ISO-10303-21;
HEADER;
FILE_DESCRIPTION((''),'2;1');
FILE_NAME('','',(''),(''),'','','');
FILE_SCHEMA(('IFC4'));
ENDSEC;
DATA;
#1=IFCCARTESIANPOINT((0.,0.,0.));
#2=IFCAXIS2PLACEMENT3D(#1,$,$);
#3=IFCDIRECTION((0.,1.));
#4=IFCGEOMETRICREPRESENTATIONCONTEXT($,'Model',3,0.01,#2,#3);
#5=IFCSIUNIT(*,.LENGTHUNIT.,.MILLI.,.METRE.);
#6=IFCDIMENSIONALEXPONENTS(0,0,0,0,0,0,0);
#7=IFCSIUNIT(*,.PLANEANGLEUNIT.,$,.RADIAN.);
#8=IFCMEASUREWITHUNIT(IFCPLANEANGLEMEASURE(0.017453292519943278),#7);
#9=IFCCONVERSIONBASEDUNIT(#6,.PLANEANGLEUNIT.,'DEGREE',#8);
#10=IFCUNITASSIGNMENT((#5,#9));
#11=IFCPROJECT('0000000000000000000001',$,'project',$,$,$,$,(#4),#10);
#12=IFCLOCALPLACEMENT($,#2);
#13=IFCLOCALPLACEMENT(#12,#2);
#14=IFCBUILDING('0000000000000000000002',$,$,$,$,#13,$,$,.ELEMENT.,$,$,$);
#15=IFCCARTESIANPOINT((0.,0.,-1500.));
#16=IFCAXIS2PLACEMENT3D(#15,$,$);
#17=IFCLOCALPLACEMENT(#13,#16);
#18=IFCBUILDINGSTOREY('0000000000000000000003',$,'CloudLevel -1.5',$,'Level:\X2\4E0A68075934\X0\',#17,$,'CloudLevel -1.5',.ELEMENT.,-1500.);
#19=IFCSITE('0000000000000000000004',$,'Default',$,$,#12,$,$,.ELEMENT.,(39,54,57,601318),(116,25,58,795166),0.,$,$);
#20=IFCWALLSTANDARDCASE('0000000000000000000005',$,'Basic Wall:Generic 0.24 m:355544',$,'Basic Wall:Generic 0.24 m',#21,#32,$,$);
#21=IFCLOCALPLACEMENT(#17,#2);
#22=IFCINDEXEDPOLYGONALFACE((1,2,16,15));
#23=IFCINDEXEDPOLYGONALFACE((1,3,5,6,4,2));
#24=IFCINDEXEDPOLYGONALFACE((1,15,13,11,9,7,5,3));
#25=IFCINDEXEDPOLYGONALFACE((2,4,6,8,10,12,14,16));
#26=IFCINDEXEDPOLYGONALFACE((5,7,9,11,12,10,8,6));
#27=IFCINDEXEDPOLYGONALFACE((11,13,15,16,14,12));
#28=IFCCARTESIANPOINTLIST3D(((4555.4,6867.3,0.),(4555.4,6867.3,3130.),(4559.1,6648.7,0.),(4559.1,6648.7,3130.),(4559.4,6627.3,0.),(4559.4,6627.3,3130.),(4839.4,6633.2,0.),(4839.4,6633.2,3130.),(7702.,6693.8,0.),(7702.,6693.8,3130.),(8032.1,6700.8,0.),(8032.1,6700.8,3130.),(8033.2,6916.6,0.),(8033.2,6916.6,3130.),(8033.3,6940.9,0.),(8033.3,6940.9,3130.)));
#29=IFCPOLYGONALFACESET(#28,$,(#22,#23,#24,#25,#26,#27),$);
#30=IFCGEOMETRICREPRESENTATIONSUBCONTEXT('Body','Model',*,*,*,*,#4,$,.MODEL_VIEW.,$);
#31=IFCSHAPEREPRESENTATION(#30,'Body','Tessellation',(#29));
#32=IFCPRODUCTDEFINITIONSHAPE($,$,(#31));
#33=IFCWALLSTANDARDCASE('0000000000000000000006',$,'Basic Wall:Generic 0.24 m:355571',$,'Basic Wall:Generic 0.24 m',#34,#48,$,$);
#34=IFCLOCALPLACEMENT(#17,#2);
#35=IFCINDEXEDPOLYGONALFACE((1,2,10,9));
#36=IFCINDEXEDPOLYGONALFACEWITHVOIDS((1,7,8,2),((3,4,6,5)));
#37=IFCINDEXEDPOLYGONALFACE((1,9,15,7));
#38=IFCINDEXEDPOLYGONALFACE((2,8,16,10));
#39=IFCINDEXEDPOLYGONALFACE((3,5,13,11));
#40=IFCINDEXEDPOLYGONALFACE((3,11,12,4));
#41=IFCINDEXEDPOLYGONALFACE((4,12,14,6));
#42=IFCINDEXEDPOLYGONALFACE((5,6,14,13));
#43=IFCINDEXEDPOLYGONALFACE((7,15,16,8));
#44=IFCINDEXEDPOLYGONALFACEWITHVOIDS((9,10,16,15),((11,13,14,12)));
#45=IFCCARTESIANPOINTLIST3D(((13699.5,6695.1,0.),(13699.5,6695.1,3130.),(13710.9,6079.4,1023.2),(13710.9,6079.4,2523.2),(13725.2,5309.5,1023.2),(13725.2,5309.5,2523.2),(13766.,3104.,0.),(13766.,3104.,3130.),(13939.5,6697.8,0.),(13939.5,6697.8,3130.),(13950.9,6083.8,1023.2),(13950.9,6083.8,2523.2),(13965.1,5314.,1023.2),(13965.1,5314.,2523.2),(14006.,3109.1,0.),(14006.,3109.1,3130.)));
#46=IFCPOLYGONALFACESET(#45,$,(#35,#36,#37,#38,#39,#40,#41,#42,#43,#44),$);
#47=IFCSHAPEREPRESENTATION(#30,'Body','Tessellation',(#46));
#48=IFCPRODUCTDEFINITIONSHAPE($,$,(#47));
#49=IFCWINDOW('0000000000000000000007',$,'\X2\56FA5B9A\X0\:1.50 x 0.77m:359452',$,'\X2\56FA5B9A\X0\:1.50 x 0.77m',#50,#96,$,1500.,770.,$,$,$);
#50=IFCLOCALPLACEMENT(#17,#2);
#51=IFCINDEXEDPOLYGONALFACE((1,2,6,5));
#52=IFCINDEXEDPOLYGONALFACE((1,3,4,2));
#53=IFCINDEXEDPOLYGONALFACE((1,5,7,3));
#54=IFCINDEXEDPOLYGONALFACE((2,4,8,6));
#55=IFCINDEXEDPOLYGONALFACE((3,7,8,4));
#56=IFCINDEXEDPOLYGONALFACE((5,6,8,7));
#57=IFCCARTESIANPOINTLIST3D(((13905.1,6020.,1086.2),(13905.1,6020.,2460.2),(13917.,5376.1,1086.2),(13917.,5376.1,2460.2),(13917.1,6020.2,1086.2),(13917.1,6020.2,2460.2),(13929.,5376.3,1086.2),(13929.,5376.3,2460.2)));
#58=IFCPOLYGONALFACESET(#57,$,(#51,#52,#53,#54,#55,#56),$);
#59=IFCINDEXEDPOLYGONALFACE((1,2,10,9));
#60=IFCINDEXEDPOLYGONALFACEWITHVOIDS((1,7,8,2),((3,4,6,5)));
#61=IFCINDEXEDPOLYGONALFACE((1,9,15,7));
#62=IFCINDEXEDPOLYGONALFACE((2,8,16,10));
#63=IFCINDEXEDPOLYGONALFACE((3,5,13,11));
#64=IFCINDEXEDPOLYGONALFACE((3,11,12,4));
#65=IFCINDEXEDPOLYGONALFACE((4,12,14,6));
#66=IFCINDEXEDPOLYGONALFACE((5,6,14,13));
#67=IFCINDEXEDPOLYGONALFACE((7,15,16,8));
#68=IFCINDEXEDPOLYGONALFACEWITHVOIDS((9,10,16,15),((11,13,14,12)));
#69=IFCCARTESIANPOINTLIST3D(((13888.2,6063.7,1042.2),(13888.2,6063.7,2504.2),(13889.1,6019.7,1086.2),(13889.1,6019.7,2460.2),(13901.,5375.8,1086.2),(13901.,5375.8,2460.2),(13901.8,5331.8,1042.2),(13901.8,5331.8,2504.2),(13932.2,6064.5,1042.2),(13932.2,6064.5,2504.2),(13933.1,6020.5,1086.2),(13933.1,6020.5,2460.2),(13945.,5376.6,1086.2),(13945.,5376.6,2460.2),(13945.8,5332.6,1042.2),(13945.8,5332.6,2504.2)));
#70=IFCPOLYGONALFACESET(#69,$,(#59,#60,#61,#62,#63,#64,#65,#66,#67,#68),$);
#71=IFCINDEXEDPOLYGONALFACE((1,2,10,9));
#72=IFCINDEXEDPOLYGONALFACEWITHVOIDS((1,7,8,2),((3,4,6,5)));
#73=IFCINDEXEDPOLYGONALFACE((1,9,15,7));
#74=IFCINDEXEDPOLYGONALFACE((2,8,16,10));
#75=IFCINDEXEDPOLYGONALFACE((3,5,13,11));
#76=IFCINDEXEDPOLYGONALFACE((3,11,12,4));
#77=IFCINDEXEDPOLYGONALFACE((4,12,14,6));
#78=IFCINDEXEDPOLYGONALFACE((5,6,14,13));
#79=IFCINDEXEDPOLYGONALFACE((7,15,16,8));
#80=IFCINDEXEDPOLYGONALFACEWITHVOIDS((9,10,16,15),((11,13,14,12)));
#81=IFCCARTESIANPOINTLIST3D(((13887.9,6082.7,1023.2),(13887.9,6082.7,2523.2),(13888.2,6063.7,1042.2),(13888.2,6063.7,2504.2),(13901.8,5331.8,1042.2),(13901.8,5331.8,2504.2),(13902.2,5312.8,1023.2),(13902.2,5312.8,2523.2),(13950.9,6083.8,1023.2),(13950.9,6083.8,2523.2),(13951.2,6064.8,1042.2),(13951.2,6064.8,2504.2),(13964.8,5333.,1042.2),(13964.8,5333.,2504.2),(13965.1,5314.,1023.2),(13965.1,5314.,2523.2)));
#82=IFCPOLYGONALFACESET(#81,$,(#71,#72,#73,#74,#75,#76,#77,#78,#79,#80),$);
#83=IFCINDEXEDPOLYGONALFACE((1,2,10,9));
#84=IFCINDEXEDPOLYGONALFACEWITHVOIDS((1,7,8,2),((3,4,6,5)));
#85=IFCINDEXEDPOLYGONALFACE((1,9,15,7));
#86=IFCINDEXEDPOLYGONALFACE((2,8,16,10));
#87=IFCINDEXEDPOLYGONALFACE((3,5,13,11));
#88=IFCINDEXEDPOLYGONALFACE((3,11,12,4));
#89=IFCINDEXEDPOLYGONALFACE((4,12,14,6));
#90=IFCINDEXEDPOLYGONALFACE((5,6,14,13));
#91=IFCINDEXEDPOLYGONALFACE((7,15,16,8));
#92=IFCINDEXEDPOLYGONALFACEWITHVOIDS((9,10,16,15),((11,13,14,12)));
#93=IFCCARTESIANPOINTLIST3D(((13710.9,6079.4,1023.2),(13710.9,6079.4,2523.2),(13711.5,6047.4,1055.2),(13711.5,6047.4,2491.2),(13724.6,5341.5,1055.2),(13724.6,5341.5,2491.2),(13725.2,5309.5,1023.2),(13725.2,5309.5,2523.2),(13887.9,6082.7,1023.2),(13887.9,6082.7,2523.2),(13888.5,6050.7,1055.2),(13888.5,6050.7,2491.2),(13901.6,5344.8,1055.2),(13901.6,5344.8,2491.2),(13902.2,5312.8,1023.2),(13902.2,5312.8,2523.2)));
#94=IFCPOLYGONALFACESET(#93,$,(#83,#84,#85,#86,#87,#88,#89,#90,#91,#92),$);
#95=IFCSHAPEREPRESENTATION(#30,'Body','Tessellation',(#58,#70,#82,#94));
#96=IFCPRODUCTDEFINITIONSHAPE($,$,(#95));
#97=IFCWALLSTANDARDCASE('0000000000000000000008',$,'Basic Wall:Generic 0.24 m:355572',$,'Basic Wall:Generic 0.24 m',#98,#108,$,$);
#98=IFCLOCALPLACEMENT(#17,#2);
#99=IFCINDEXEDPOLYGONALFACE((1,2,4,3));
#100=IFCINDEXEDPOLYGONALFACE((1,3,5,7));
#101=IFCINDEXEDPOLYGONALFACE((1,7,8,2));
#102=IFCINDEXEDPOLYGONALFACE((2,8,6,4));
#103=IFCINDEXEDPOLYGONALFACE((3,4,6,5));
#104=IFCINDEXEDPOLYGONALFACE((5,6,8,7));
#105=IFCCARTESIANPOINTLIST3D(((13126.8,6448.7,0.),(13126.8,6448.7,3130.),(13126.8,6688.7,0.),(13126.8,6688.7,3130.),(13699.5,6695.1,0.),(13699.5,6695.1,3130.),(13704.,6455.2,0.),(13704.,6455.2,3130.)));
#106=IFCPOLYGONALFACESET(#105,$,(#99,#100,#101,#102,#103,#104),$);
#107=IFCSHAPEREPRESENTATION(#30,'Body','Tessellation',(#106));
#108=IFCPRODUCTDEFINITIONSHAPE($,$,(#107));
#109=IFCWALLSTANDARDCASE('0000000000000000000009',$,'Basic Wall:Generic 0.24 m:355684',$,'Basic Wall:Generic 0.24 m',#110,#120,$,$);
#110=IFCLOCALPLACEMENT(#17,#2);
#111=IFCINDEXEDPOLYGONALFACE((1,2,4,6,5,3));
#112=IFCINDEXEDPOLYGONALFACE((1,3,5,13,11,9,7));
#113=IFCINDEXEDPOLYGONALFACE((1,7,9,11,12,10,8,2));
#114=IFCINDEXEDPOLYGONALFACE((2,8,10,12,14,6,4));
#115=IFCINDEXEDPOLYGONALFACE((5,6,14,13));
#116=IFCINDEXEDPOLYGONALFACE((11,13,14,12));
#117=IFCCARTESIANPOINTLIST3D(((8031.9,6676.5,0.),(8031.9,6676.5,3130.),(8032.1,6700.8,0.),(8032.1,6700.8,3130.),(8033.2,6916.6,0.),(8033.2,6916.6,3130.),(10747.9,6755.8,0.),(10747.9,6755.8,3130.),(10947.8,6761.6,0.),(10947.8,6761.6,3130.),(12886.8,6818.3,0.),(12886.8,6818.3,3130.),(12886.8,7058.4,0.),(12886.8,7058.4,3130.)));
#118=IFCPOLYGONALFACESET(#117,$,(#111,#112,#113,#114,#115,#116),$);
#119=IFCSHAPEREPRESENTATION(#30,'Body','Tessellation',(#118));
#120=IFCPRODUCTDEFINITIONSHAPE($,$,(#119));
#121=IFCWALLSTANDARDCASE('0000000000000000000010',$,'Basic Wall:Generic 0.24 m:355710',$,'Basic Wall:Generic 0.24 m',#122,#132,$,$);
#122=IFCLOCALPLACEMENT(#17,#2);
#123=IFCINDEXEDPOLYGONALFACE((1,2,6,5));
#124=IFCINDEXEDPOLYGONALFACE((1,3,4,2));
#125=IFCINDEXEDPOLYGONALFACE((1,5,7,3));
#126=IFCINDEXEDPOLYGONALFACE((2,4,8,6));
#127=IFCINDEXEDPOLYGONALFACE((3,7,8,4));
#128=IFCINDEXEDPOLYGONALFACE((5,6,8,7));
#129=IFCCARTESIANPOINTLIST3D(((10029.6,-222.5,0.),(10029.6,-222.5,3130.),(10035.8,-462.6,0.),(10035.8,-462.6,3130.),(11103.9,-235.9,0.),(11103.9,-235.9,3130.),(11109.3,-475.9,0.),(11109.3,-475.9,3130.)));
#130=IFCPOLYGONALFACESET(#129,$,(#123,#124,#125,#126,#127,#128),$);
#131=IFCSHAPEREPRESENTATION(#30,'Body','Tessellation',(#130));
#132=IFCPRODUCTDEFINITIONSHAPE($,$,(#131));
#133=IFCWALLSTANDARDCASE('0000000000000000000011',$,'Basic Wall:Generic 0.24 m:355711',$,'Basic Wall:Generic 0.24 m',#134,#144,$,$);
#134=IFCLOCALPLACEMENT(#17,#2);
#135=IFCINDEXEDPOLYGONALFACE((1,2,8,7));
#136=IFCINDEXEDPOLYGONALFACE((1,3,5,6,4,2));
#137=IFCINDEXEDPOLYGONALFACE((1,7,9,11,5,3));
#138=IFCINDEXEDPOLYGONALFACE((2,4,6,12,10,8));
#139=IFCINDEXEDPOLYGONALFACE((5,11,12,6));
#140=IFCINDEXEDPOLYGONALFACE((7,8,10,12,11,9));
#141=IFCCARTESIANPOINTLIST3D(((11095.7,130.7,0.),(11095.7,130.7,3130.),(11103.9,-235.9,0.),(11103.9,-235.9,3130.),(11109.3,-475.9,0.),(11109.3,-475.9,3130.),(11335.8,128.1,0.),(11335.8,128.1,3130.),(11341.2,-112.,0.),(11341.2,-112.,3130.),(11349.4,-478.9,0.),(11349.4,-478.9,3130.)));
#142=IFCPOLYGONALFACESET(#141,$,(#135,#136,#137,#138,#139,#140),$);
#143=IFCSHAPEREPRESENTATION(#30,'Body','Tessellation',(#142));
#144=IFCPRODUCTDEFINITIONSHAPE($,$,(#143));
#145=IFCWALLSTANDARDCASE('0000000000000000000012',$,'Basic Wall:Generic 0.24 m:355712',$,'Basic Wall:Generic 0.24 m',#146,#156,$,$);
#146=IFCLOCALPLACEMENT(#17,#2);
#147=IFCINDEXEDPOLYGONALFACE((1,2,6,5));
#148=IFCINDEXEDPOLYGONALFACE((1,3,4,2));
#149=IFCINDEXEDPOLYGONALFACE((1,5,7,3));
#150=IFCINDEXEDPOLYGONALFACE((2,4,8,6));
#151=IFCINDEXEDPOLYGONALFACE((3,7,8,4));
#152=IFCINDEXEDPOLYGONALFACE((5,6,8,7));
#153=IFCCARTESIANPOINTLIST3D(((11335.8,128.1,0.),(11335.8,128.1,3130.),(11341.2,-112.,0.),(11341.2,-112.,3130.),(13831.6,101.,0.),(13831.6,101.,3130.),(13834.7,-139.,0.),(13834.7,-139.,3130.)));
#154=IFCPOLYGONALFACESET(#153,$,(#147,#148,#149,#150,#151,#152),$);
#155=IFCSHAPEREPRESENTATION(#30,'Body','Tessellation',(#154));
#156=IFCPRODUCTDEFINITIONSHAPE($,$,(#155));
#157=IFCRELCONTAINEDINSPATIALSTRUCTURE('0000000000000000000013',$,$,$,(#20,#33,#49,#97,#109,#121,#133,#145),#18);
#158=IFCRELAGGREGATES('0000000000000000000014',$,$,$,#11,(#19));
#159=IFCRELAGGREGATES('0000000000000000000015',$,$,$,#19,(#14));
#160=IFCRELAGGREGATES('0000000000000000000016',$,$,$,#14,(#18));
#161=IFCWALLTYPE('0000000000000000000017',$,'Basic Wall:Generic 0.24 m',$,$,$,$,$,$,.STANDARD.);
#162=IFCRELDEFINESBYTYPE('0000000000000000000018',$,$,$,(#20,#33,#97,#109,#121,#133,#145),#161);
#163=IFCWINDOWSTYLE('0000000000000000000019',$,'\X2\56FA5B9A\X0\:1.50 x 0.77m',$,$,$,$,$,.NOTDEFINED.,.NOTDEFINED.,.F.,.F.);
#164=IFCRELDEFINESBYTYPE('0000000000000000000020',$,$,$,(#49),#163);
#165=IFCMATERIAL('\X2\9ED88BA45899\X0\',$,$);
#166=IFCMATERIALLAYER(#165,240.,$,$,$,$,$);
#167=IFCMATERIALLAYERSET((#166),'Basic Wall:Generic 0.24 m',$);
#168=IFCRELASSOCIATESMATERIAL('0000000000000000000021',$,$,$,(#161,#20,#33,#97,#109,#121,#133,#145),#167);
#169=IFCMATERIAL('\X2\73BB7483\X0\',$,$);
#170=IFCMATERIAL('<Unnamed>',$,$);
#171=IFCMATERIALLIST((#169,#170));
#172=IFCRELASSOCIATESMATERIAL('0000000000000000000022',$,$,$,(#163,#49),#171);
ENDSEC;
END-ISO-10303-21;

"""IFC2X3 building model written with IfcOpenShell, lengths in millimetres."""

from ifc_helpers import new_model, entity, si_unit, converted_unit, direction, frame, frame_2d, origin, place, context, subcontext, project, spatial, polyline, rectangle, outline, extrude, source, transform, mapped, material, material_list, layer, layer_set, layer_usage, type_object, type_shapes, element, fill, save


model = new_model("IFC2X3")

# Units and contexts
model_context = context("Model", 3, precision=0.01, world=origin(), true_north=direction((0.0, 1.0)))
body_context = subcontext(model_context, "Body", "Model", "MODEL_VIEW")
ifc_project = project(units=[si_unit("LENGTHUNIT", "METRE", prefix="MILLI"), converted_unit("PLANEANGLEUNIT", "DEGREE", entity("IfcPlaneAngleMeasure", 0.017453292519943278), si_unit("PLANEANGLEUNIT", "RADIAN"), dimensions=[0, 0, 0, 0, 0, 0, 0])], contexts=[model_context])

# Site, building, storey
site_placement = place(None, origin())
site = spatial("IfcSite", under=ifc_project, at=site_placement, Name="Default", CompositionType="ELEMENT", RefLatitude=(39, 54, 57, 601318), RefLongitude=(116, 25, 58, 795166), RefElevation=0.0)
building_placement = place(site_placement, origin())
building = spatial("IfcBuilding", under=site, at=building_placement, CompositionType="ELEMENT")
storey_placement = place(building_placement, frame((0.0, 0.0, -1500.0)))
storey = spatial("IfcBuildingStorey", under=building, at=storey_placement, Name="CloudLevel -1.5", ObjectType="Level:上标头", LongName="CloudLevel -1.5", CompositionType="ELEMENT", Elevation=-1500.0)

# Wall
ifc_material_1 = material(Name="默认墙")
ifc_layer_1 = layer(ifc_material_1, 240.0)
ifc_layer_set_1 = layer_set([ifc_layer_1], Name="Basic Wall:Generic 0.24 m")
ifc_layer_usage_1 = layer_usage(ifc_layer_set_1, "AXIS2", "NEGATIVE", 120.0)
wall_type_1 = type_object("IfcWallType", Name="Basic Wall:Generic 0.24 m", PredefinedType="STANDARD", material=ifc_layer_set_1)
wall_1_placement = place(storey_placement, frame((8035.9, 6820.9, 0.0), z_axis=(0.0, 0.0, 1.0), x_axis=(-0.999776, -0.021161, 0.0)))
element("IfcWallStandardCase", 1, at=wall_1_placement, inside=storey, type_object=wall_type_1, material=ifc_layer_usage_1, Name="Basic Wall:Generic 0.24 m:355544", ObjectType="Basic Wall:Generic 0.24 m", context=body_context, shape_type="SweptSolid", body=[
    extrude(outline(polyline([(3478.7, -120.0), (3479.7, 98.6), (3479.8, 120.0), (3199.7, 120.0), (336.4, 120.0), (6.3, 120.0), (0.6, -95.7), (0.0, -120.0), (3478.7, -120.0)])), origin(), (0.0, 0.0, 1.0), 3130.0),
])

# Wall, opening, window
wall_2_placement = place(storey_placement, frame((13886.0, 3106.2, 0.0), z_axis=(0.0, 0.0, 1.0), x_axis=(-0.018522, 0.999828, 0.0)))
wall_2 = element("IfcWallStandardCase", 2, at=wall_2_placement, inside=storey, type_object=wall_type_1, material=ifc_layer_usage_1, Name="Basic Wall:Generic 0.24 m:355571", ObjectType="Basic Wall:Generic 0.24 m", context=body_context, shape_type="SweptSolid", body=[
    extrude(outline(polyline([(3590.0, -120.0), (3591.8, 120.0), (3351.8, 120.0), (1772.5, 120.0), (1662.5, 120.0), (0.0, 120.0), (0.7, -120.0), (3590.0, -120.0)])), origin(), (0.0, 0.0, 1.0), 3130.0),
])
opening_1_placement = place(wall_2_placement, frame((2975.9, 120.0, 1023.2)))
opening_1 = element("IfcOpeningElement", 3, at=opening_1_placement, cuts=wall_2, ObjectType="Opening", context=body_context, shape_type="SweptSolid", body=[
    extrude(rectangle(XDim=1500.0, YDim=770.0, at=frame_2d((750.0, 385.0), x_axis=(1.0, 0.0))), frame((0.0, 0.0, 0.0), z_axis=(0.0, -1.0, 0.0), x_axis=(0.0, 0.0, 1.0)), (0.0, 0.0, 1.0), 240.0),
])
ifc_material_2 = material(Name="玻璃")
ifc_material_3 = material(Name="<Unnamed>")
ifc_material_list_1 = material_list([ifc_material_2, ifc_material_3])
window_style_1 = type_object("IfcWindowStyle", Name="固定:1.50 x 0.77m", ConstructionType="NOTDEFINED", OperationType="NOTDEFINED", ParameterTakesPrecedence=False, Sizeable=False, material=ifc_material_list_1)
shared_shape_1 = source(origin(), body_context, "Body", "SweptSolid", [
    extrude(rectangle(XDim=644.0, YDim=12.0, at=frame_2d((0.0, 0.0), x_axis=(1.0, 0.0))), frame((385.0, 225.0, 63.0), z_axis=(0.0, 0.0, 1.0), x_axis=(-1.0, 0.0, 0.0)), (0.0, 0.0, 1.0), 1374.0),
    extrude(outline(polyline([(-366.0, -731.0), (366.0, -731.0), (366.0, 731.0), (-366.0, 731.0), (-366.0, -731.0)]), holes=[polyline([(-322.0, -687.0), (-322.0, 687.0), (322.0, 687.0), (322.0, -687.0), (-322.0, -687.0)])]), frame((385.0, 247.0, 750.0), z_axis=(0.0, -1.0, 0.0), x_axis=(-1.0, 0.0, 0.0)), (0.0, 0.0, 1.0), 44.0),
    extrude(outline(polyline([(-385.0, -750.0), (385.0, -750.0), (385.0, 750.0), (-385.0, 750.0), (-385.0, -750.0)]), holes=[polyline([(-366.0, -731.0), (-366.0, 731.0), (366.0, 731.0), (366.0, -731.0), (-366.0, -731.0)])]), frame((385.0, 266.0, 750.0), z_axis=(0.0, -1.0, 0.0), x_axis=(-1.0, 0.0, 0.0)), (0.0, 0.0, 1.0), 63.0),
    extrude(outline(polyline([(-385.0, -750.0), (385.0, -750.0), (385.0, 750.0), (-385.0, 750.0), (-385.0, -750.0)]), holes=[polyline([(-353.0, -718.0), (-353.0, 718.0), (353.0, 718.0), (353.0, -718.0), (-353.0, -718.0)])]), frame((385.0, 203.0, 750.0), z_axis=(0.0, -1.0, 0.0), x_axis=(-1.0, 0.0, 0.0)), (0.0, 0.0, 1.0), 177.0),
])
type_shapes(window_style_1, [shared_shape_1])
window_1_placement = place(opening_1_placement, frame((0.0, 26.0, 0.0), z_axis=(0.0, 0.0, 1.0), x_axis=(-1.0, 0.0, 0.0)))
window_1 = element("IfcWindow", 4, at=window_1_placement, inside=storey, type_object=window_style_1, material=ifc_material_list_1, Name="固定:1.50 x 0.77m:359452", ObjectType="固定:1.50 x 0.77m", OverallHeight=1500.0, OverallWidth=770.0, context=body_context, shape_type="MappedRepresentation", body=[
    mapped(shared_shape_1, transform((0.0, 0.0, 0.0), scale=1.0)),
])
fill(opening_1, window_1)

# Walls
wall_3_placement = place(storey_placement, frame((13125.4, 6568.7, 0.0), z_axis=(0.0, 0.0, 1.0), x_axis=(0.999937, 0.011183, 0.0)))
element("IfcWallStandardCase", 5, at=wall_3_placement, inside=storey, type_object=wall_type_1, material=ifc_layer_usage_1, Name="Basic Wall:Generic 0.24 m:355572", ObjectType="Basic Wall:Generic 0.24 m", context=body_context, shape_type="SweptSolid", body=[
    extrude(outline(polyline([(577.2, -120.0), (575.5, 120.0), (2.7, 120.0), (0.0, -120.0), (577.2, -120.0)])), origin(), (0.0, 0.0, 1.0), 3130.0),
])
wall_4_placement = place(storey_placement, frame((12890.3, 6938.4, 0.0), z_axis=(0.0, 0.0, 1.0), x_axis=(-0.999574, -0.029193, 0.0)))
element("IfcWallStandardCase", 6, at=wall_4_placement, inside=storey, type_object=wall_type_1, material=ifc_layer_usage_1, Name="Basic Wall:Generic 0.24 m:355684", ObjectType="Basic Wall:Generic 0.24 m", context=body_context, shape_type="SweptSolid", body=[
    extrude(outline(polyline([(4855.7, -120.0), (4863.1, 95.7), (4863.9, 120.0), (2146.8, 120.0), (1946.8, 120.0), (7.0, 120.0), (0.0, -120.0), (4855.7, -120.0)])), origin(), (0.0, 0.0, 1.0), 3130.0),
])
wall_5_placement = place(storey_placement, frame((11110.8, -356.0, 0.0), z_axis=(0.0, 0.0, 1.0), x_axis=(-0.999923, 0.012446, 0.0)))
element("IfcWallStandardCase", 7, at=wall_5_placement, inside=storey, type_object=wall_type_1, material=ifc_layer_usage_1, Name="Basic Wall:Generic 0.24 m:355710", ObjectType="Basic Wall:Generic 0.24 m", context=body_context, shape_type="SweptSolid", body=[
    extrude(outline(polyline([(1082.8, -120.0), (1073.6, 120.0), (0.0, 120.0), (8.4, -120.0), (1082.8, -120.0)])), origin(), (0.0, 0.0, 1.0), 3130.0),
])
wall_6_placement = place(storey_placement, frame((11215.7, 133.4, 0.0), z_axis=(0.0, 0.0, 1.0), x_axis=(0.022416, -0.999749, 0.0)))
element("IfcWallStandardCase", 8, at=wall_6_placement, inside=storey, type_object=wall_type_1, material=ifc_layer_usage_1, Name="Basic Wall:Generic 0.24 m:355711", ObjectType="Basic Wall:Generic 0.24 m", context=body_context, shape_type="SweptSolid", body=[
    extrude(outline(polyline([(606.8, -120.0), (615.1, 120.0), (248.1, 120.0), (8.0, 120.0), (0.0, -120.0), (366.6, -120.0), (606.8, -120.0)])), origin(), (0.0, 0.0, 1.0), 3130.0),
])
wall_7_placement = place(storey_placement, frame((13836.0, -19.0, 0.0), z_axis=(0.0, 0.0, 1.0), x_axis=(-0.999941, 0.010833, 0.0)))
element("IfcWallStandardCase", 9, at=wall_7_placement, inside=storey, type_object=wall_type_1, material=ifc_layer_usage_1, Name="Basic Wall:Generic 0.24 m:355712", ObjectType="Basic Wall:Generic 0.24 m", context=body_context, shape_type="SweptSolid", body=[
    extrude(outline(polyline([(2501.7, -120.0), (2493.7, 120.0), (0.0, 120.0), (5.7, -120.0), (2501.7, -120.0)])), origin(), (0.0, 0.0, 1.0), 3130.0),
])

save(model, "model.ifc")
